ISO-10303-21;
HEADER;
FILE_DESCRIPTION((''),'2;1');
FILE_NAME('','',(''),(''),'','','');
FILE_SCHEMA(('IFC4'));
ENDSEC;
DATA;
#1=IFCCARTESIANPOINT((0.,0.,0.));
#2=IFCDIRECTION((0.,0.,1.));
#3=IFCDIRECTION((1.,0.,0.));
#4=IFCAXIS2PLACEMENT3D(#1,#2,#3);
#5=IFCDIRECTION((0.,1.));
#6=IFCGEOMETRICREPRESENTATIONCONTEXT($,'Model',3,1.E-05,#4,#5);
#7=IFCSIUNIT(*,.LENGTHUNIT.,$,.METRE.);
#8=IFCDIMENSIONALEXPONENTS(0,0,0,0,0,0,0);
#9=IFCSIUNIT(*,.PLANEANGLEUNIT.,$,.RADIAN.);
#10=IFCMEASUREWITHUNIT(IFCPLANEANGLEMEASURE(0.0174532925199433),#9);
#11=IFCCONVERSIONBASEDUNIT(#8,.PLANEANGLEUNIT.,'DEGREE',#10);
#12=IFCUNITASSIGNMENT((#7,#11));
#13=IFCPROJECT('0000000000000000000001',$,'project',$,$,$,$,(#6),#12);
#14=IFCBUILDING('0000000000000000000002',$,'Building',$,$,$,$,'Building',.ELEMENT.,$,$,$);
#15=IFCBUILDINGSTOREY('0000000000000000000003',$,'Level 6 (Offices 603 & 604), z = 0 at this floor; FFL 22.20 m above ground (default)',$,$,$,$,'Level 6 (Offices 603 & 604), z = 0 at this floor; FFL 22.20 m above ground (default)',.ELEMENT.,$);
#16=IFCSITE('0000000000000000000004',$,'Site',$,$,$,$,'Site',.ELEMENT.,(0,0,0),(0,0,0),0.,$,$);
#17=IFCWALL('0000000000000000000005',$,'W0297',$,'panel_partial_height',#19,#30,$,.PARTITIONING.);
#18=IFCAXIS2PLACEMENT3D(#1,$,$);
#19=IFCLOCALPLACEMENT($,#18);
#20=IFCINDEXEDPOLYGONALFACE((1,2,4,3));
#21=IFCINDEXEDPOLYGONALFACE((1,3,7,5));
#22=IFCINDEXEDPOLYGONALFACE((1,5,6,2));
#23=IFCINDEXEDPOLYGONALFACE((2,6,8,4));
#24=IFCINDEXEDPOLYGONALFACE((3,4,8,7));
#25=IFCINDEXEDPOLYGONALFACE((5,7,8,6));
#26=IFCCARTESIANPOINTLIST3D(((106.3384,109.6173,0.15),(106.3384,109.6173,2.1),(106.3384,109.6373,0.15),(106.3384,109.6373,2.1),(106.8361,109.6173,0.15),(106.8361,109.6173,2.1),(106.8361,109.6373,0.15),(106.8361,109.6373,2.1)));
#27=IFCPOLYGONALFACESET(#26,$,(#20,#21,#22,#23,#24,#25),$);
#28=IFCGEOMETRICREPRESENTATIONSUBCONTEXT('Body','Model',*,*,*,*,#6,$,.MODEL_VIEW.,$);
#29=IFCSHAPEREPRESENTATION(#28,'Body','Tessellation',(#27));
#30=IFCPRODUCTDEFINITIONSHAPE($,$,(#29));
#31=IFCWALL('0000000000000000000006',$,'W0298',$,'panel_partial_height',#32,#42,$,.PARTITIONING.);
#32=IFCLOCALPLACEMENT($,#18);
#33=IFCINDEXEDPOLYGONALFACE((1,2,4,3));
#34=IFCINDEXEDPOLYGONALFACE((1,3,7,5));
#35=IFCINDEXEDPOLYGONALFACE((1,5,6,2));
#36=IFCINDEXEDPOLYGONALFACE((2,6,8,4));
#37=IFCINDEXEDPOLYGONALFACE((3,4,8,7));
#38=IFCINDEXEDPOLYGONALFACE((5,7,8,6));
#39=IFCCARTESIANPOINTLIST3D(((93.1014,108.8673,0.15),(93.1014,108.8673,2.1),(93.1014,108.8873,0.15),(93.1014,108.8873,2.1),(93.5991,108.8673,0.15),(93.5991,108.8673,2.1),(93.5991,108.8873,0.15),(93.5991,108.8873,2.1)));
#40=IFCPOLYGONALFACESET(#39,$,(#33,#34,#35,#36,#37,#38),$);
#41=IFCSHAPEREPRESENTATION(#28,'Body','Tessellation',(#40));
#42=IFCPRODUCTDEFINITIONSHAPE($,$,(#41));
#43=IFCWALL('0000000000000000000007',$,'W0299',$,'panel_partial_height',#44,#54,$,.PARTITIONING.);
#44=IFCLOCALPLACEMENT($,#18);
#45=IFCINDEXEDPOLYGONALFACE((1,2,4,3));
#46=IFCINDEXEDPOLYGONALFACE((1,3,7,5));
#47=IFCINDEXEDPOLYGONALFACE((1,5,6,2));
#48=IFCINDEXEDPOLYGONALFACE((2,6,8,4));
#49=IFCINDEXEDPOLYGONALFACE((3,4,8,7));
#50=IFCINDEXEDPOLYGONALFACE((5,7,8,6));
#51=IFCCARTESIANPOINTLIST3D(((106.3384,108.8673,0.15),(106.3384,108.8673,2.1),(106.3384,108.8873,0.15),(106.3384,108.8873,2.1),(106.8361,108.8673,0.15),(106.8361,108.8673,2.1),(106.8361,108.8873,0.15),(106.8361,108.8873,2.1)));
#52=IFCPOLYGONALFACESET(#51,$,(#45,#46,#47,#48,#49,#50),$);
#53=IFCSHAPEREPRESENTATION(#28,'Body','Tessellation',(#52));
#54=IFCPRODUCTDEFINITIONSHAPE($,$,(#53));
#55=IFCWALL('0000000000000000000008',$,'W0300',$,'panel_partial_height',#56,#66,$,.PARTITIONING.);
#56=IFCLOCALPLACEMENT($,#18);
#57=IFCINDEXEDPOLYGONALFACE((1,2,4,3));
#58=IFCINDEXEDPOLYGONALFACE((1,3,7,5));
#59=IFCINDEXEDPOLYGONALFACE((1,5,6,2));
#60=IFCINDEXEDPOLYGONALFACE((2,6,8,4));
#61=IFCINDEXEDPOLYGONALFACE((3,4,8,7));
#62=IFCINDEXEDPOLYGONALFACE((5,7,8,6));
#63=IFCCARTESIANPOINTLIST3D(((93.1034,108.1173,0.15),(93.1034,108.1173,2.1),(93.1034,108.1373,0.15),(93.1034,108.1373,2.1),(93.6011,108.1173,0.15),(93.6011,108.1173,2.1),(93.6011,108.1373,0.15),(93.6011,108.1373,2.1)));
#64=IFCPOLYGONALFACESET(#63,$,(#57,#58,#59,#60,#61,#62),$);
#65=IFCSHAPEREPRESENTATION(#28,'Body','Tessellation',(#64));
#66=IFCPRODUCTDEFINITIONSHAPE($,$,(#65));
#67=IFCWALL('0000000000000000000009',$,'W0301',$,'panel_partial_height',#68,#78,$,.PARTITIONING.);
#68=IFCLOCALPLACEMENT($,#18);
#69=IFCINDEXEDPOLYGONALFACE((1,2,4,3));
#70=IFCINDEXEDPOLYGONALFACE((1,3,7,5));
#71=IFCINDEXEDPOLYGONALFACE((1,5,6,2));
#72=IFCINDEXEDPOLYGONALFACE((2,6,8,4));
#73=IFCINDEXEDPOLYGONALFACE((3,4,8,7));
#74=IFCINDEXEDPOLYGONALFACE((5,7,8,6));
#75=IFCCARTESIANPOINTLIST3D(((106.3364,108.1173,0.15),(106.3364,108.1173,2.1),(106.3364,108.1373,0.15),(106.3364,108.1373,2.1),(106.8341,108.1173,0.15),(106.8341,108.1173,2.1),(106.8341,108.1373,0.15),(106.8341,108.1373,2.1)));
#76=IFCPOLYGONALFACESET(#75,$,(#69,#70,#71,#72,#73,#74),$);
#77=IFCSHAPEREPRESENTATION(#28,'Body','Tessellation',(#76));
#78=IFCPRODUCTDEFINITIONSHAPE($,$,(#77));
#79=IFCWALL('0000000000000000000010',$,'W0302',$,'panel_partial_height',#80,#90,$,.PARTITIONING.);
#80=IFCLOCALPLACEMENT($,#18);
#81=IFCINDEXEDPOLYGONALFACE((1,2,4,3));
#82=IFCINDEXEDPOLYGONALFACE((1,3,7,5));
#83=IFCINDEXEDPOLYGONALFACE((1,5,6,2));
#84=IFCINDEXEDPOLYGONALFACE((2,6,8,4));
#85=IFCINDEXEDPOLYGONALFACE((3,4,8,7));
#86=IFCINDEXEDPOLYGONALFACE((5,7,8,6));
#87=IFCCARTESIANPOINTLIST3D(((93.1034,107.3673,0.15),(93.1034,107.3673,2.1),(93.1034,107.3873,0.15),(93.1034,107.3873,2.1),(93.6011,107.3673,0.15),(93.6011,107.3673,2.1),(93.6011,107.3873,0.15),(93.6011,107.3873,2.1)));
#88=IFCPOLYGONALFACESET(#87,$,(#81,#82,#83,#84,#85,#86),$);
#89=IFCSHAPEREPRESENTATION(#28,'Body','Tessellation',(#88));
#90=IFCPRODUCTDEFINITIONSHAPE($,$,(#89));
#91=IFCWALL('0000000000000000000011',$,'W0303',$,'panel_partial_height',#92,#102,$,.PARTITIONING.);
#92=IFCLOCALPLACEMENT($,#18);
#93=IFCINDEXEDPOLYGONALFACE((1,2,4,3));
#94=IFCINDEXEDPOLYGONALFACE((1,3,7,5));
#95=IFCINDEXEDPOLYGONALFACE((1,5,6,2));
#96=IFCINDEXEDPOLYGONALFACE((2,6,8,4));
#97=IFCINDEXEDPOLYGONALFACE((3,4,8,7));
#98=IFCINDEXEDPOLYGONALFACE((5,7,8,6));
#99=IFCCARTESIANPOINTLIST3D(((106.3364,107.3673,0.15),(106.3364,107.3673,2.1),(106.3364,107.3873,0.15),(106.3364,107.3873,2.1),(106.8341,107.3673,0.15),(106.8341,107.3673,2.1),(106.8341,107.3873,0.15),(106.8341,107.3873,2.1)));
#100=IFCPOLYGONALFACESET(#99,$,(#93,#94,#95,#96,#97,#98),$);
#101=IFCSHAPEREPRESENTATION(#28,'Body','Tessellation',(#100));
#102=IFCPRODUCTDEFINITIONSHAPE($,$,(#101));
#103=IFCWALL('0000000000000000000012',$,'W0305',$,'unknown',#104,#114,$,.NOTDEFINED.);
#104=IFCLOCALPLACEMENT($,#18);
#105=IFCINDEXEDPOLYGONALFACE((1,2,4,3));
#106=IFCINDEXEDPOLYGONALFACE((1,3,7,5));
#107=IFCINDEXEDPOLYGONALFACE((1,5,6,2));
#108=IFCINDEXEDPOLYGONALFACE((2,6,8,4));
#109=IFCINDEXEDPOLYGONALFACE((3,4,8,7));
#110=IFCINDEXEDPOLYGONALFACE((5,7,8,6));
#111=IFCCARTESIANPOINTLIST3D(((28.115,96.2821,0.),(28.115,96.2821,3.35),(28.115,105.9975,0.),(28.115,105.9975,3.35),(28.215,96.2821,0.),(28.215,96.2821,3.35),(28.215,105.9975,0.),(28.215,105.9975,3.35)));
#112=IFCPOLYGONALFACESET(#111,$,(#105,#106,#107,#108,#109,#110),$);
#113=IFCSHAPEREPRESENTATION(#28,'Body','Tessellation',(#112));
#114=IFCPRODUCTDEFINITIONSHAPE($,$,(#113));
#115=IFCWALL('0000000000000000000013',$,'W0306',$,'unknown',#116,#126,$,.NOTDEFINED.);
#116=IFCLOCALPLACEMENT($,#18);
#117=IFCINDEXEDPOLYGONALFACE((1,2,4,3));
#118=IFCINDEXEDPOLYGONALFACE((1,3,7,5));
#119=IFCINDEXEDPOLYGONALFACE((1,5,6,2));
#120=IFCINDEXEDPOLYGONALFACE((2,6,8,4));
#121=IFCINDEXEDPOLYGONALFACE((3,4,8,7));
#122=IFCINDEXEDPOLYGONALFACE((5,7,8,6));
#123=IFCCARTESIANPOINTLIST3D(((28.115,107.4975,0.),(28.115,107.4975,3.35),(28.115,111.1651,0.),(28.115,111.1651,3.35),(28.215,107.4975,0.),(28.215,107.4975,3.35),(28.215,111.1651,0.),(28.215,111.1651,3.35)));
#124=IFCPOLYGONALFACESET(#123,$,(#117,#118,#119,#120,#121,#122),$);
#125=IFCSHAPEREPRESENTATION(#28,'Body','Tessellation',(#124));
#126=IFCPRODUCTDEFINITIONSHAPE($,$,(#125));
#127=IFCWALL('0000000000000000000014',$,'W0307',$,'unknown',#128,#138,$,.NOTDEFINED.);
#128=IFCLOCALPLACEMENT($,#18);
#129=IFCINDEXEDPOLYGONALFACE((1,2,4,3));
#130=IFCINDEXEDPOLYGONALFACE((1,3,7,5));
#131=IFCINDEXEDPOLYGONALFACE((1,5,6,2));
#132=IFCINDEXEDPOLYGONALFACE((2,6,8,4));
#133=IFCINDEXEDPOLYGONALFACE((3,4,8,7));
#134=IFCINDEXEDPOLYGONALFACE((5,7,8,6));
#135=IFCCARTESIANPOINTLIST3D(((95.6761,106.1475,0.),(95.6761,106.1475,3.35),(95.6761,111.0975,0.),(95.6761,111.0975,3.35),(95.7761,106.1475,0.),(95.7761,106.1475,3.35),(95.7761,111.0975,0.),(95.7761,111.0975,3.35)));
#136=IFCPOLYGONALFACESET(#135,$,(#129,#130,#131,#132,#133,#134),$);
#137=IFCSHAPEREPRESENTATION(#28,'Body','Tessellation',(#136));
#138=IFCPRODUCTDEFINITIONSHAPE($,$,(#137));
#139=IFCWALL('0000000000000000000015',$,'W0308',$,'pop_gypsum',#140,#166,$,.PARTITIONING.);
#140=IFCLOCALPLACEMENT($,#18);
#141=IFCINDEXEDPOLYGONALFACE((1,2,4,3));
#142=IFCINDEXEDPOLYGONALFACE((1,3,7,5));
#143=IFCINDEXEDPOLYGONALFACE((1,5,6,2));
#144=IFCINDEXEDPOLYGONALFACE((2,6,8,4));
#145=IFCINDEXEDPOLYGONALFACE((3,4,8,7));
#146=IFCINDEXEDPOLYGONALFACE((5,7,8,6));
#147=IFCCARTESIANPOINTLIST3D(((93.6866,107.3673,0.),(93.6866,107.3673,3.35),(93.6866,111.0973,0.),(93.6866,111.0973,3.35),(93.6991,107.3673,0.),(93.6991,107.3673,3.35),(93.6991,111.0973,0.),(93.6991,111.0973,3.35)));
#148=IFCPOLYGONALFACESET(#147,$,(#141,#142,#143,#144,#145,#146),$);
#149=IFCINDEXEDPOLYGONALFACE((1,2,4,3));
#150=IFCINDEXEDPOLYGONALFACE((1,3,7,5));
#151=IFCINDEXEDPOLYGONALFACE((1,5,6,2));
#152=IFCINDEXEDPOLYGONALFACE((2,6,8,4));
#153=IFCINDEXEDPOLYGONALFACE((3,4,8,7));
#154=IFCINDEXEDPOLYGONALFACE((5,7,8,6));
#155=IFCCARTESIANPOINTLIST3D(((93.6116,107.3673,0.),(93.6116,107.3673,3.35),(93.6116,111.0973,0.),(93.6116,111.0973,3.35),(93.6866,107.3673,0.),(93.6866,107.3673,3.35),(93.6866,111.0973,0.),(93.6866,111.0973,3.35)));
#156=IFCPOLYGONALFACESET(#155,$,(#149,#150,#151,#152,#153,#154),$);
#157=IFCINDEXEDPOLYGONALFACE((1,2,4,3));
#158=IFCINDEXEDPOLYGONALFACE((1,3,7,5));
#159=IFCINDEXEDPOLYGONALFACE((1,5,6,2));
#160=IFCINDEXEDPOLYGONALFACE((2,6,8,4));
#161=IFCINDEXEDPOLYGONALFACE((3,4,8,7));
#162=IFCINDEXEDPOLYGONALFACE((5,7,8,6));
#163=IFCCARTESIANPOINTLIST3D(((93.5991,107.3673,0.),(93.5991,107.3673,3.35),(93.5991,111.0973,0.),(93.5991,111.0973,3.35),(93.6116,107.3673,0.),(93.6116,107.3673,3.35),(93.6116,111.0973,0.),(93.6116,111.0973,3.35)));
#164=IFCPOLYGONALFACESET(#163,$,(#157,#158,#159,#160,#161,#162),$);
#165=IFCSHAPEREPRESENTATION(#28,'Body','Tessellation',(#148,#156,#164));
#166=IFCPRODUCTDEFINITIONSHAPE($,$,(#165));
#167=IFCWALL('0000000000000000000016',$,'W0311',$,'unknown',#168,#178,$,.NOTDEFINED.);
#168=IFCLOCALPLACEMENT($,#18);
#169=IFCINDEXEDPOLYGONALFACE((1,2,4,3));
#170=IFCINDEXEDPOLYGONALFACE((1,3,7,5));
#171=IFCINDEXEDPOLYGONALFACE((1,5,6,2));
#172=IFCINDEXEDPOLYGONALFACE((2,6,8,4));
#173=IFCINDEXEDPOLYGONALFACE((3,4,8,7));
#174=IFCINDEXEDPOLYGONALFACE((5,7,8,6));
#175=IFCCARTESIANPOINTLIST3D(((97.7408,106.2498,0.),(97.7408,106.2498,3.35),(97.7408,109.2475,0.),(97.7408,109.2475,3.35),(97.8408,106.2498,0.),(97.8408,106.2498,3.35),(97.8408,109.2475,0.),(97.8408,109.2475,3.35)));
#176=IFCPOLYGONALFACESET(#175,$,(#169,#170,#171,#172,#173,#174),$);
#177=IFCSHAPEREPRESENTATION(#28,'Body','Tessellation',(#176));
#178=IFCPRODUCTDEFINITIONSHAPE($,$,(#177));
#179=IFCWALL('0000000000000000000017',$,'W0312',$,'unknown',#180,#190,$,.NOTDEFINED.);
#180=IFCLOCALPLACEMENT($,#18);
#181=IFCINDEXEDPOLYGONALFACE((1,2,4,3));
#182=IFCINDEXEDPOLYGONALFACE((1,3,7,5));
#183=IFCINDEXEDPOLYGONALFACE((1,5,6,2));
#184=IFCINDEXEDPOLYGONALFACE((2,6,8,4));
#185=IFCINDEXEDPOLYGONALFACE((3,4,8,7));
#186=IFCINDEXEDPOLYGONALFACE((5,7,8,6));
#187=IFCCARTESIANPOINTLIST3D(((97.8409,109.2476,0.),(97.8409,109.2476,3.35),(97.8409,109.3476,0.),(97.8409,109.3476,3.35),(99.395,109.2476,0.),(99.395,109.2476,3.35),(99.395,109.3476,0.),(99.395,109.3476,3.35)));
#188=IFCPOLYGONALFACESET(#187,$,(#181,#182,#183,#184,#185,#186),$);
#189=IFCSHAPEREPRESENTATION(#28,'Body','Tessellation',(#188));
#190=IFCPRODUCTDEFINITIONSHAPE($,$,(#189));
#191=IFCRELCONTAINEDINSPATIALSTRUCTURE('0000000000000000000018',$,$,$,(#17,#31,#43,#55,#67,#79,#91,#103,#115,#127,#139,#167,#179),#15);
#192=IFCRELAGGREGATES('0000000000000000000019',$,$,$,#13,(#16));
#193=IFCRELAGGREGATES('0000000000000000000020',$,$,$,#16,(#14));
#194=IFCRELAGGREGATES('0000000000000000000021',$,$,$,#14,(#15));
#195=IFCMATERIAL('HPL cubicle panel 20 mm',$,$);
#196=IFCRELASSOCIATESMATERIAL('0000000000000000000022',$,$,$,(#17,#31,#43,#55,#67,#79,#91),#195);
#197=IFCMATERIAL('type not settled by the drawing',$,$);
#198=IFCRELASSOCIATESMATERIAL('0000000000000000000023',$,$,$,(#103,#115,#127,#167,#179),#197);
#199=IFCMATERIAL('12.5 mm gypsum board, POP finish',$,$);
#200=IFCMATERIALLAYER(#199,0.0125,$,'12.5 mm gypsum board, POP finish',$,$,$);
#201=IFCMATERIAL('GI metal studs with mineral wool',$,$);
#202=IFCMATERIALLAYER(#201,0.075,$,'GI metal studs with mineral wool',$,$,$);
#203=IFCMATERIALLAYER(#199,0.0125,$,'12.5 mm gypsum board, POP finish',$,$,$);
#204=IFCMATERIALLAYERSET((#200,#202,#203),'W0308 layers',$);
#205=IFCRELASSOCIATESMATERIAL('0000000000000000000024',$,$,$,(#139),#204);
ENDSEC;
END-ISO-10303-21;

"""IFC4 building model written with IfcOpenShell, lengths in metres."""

from ifc_helpers import new_model, entity, si_unit, converted_unit, direction, frame, frame_2d, origin_with_axes, origin_2d_with_axis, place, context, subcontext, project, spatial, rectangle, extrude, material, layer, layer_set, layer_usage, element, save


model = new_model("IFC4")

# Units and contexts
model_context = context("Model", 3, precision=1e-05, world=origin_with_axes(), true_north=direction((0.0, 1.0)))
body_context = subcontext(model_context, "Body", "Model", "MODEL_VIEW")
ifc_project = project(units=[si_unit("LENGTHUNIT", "METRE"), converted_unit("PLANEANGLEUNIT", "DEGREE", entity("IfcPlaneAngleMeasure", 0.0174532925199433), si_unit("PLANEANGLEUNIT", "RADIAN"), dimensions=[0, 0, 0, 0, 0, 0, 0])], contexts=[model_context])

# Site, building, storey
site = spatial("IfcSite", under=ifc_project, Name="Site", LongName="Site", CompositionType="ELEMENT", RefLatitude=(0, 0, 0), RefLongitude=(0, 0, 0), RefElevation=0.0)
building = spatial("IfcBuilding", under=site, Name="Building", LongName="Building", CompositionType="ELEMENT")
storey = spatial("IfcBuildingStorey", under=building, Name="Level 6 (Offices 603 & 604), z = 0 at this floor; FFL 22.20 m above ground (default)", LongName="Level 6 (Offices 603 & 604), z = 0 at this floor; FFL 22.20 m above ground (default)", CompositionType="ELEMENT")

# Walls
ifc_material_1 = material(Name="12.5 mm gypsum board, POP finish")
ifc_material_2 = material(Name="GI metal studs with mineral wool")
placement = place(None, origin_with_axes())
ifc_material_3 = material(Name="HPL cubicle panel 20 mm")
element("IfcWall", 1, at=placement, inside=storey, material=ifc_material_3, Name="W0297", ObjectType="panel_partial_height", PredefinedType="PARTITIONING", context=body_context, shape_type="SweptSolid", body=[
    extrude(rectangle(XDim=0.4977, YDim=0.02, at=frame_2d((0.0, 0.0), x_axis=(1.0, 0.0))), frame((106.5872, 109.6273, 0.15), z_axis=(0.0, 0.0, 1.0), x_axis=(1.0, 0.0, 0.0)), (0.0, 0.0, 1.0), 1.95),
])
element("IfcWall", 2, at=placement, inside=storey, material=ifc_material_3, Name="W0298", ObjectType="panel_partial_height", PredefinedType="PARTITIONING", context=body_context, shape_type="SweptSolid", body=[
    extrude(rectangle(XDim=0.4977, YDim=0.02, at=origin_2d_with_axis()), frame((93.3503, 108.8773, 0.15), z_axis=(0.0, 0.0, 1.0), x_axis=(1.0, 0.0, 0.0)), (0.0, 0.0, 1.0), 1.95),
])
element("IfcWall", 3, at=placement, inside=storey, material=ifc_material_3, Name="W0299", ObjectType="panel_partial_height", PredefinedType="PARTITIONING", context=body_context, shape_type="SweptSolid", body=[
    extrude(rectangle(XDim=0.4977, YDim=0.02, at=origin_2d_with_axis()), frame((106.5872, 108.8773, 0.15), z_axis=(0.0, 0.0, 1.0), x_axis=(1.0, 0.0, 0.0)), (0.0, 0.0, 1.0), 1.95),
])
element("IfcWall", 4, at=placement, inside=storey, material=ifc_material_3, Name="W0300", ObjectType="panel_partial_height", PredefinedType="PARTITIONING", context=body_context, shape_type="SweptSolid", body=[
    extrude(rectangle(XDim=0.4977, YDim=0.02, at=frame_2d((0.0, 0.0), x_axis=(1.0, 0.0))), frame((93.3522, 108.1273, 0.15), z_axis=(0.0, 0.0, 1.0), x_axis=(1.0, 0.0, 0.0)), (0.0, 0.0, 1.0), 1.95),
])
element("IfcWall", 5, at=placement, inside=storey, material=ifc_material_3, Name="W0301", ObjectType="panel_partial_height", PredefinedType="PARTITIONING", context=body_context, shape_type="SweptSolid", body=[
    extrude(rectangle(XDim=0.4977, YDim=0.02, at=frame_2d((0.0, 0.0), x_axis=(1.0, 0.0))), frame((106.5853, 108.1273, 0.15), z_axis=(0.0, 0.0, 1.0), x_axis=(1.0, 0.0, 0.0)), (0.0, 0.0, 1.0), 1.95),
])
element("IfcWall", 6, at=placement, inside=storey, material=ifc_material_3, Name="W0302", ObjectType="panel_partial_height", PredefinedType="PARTITIONING", context=body_context, shape_type="SweptSolid", body=[
    extrude(rectangle(XDim=0.4977, YDim=0.02, at=frame_2d((0.0, 0.0), x_axis=(1.0, 0.0))), frame((93.3522, 107.3773, 0.15), z_axis=(0.0, 0.0, 1.0), x_axis=(1.0, 0.0, 0.0)), (0.0, 0.0, 1.0), 1.95),
])
element("IfcWall", 7, at=placement, inside=storey, material=ifc_material_3, Name="W0303", ObjectType="panel_partial_height", PredefinedType="PARTITIONING", context=body_context, shape_type="SweptSolid", body=[
    extrude(rectangle(XDim=0.4977, YDim=0.02, at=frame_2d((0.0, 0.0), x_axis=(1.0, 0.0))), frame((106.5853, 107.3773, 0.15), z_axis=(0.0, 0.0, 1.0), x_axis=(1.0, 0.0, 0.0)), (0.0, 0.0, 1.0), 1.95),
])
ifc_material_4 = material(Name="type not settled by the drawing")
element("IfcWall", 8, at=placement, inside=storey, material=ifc_material_4, Name="W0305", ObjectType="unknown", PredefinedType="NOTDEFINED", context=body_context, shape_type="SweptSolid", body=[
    extrude(rectangle(XDim=9.7154, YDim=0.1, at=frame_2d((0.0, 0.0), x_axis=(0.0, 1.0))), frame((28.165, 101.1398, 0.0), z_axis=(0.0, 0.0, 1.0), x_axis=(1.0, 0.0, 0.0)), (0.0, 0.0, 1.0), 3.35),
])
element("IfcWall", 9, at=placement, inside=storey, material=ifc_material_4, Name="W0306", ObjectType="unknown", PredefinedType="NOTDEFINED", context=body_context, shape_type="SweptSolid", body=[
    extrude(rectangle(XDim=3.6676, YDim=0.1, at=frame_2d((0.0, 0.0), x_axis=(0.0, 1.0))), frame((28.165, 109.3313, 0.0), z_axis=(0.0, 0.0, 1.0), x_axis=(1.0, 0.0, 0.0)), (0.0, 0.0, 1.0), 3.35),
])
element("IfcWall", 10, at=placement, inside=storey, material=ifc_material_4, Name="W0307", ObjectType="unknown", PredefinedType="NOTDEFINED", context=body_context, shape_type="SweptSolid", body=[
    extrude(rectangle(XDim=4.95, YDim=0.1, at=frame_2d((0.0, 0.0), x_axis=(0.0, 1.0))), frame((95.7261, 108.6225, 0.0), z_axis=(0.0, 0.0, 1.0), x_axis=(1.0, 0.0, 0.0)), (0.0, 0.0, 1.0), 3.35),
])
ifc_layer_1 = layer(ifc_material_1, 0.0125, Name="12.5 mm gypsum board, POP finish")
ifc_layer_2 = layer(ifc_material_2, 0.075, Name="GI metal studs with mineral wool")
ifc_layer_3 = layer(ifc_material_1, 0.0125, Name="12.5 mm gypsum board, POP finish")
ifc_layer_set_1 = layer_set([ifc_layer_1, ifc_layer_2, ifc_layer_3], Name="W0308 layers")
ifc_layer_usage_1 = layer_usage(ifc_layer_set_1, "AXIS2", "POSITIVE", -0.05)
element("IfcWall", 11, at=placement, inside=storey, material=ifc_layer_usage_1, Name="W0308", ObjectType="pop_gypsum", PredefinedType="PARTITIONING", context=body_context, shape_type="SweptSolid", body=[
    extrude(rectangle(XDim=3.73, YDim=0.0125, at=frame_2d((0.0, 0.0), x_axis=(0.0, 1.0))), frame((93.6929, 109.2323, 0.0), z_axis=(0.0, 0.0, 1.0), x_axis=(1.0, 0.0, 0.0)), (0.0, 0.0, 1.0), 3.35),
    extrude(rectangle(XDim=3.73, YDim=0.075, at=frame_2d((-0.0437, 0.0), x_axis=(0.0, 1.0))), frame((93.6929, 109.2323, 0.0), z_axis=(0.0, 0.0, 1.0), x_axis=(1.0, 0.0, 0.0)), (0.0, 0.0, 1.0), 3.35),
    extrude(rectangle(XDim=3.73, YDim=0.0125, at=frame_2d((-0.0875, 0.0), x_axis=(0.0, 1.0))), frame((93.6929, 109.2323, 0.0), z_axis=(0.0, 0.0, 1.0), x_axis=(1.0, 0.0, 0.0)), (0.0, 0.0, 1.0), 3.35),
])
element("IfcWall", 12, at=placement, inside=storey, material=ifc_material_4, Name="W0311", ObjectType="unknown", PredefinedType="NOTDEFINED", context=body_context, shape_type="SweptSolid", body=[
    extrude(rectangle(XDim=2.9977, YDim=0.1001, at=frame_2d((0.0, 0.0), x_axis=(0.0, 1.0))), frame((97.7908, 107.7486, 0.0), z_axis=(0.0, 0.0, 1.0), x_axis=(1.0, 0.0, 0.0)), (0.0, 0.0, 1.0), 3.35),
])
element("IfcWall", 13, at=placement, inside=storey, material=ifc_material_4, Name="W0312", ObjectType="unknown", PredefinedType="NOTDEFINED", context=body_context, shape_type="SweptSolid", body=[
    extrude(rectangle(XDim=1.5541, YDim=0.1001, at=origin_2d_with_axis()), frame((98.6179, 109.2976, 0.0), z_axis=(0.0, 0.0, 1.0), x_axis=(1.0, 0.0, 0.0)), (0.0, 0.0, 1.0), 3.35),
])

save(model, "model.ifc")
